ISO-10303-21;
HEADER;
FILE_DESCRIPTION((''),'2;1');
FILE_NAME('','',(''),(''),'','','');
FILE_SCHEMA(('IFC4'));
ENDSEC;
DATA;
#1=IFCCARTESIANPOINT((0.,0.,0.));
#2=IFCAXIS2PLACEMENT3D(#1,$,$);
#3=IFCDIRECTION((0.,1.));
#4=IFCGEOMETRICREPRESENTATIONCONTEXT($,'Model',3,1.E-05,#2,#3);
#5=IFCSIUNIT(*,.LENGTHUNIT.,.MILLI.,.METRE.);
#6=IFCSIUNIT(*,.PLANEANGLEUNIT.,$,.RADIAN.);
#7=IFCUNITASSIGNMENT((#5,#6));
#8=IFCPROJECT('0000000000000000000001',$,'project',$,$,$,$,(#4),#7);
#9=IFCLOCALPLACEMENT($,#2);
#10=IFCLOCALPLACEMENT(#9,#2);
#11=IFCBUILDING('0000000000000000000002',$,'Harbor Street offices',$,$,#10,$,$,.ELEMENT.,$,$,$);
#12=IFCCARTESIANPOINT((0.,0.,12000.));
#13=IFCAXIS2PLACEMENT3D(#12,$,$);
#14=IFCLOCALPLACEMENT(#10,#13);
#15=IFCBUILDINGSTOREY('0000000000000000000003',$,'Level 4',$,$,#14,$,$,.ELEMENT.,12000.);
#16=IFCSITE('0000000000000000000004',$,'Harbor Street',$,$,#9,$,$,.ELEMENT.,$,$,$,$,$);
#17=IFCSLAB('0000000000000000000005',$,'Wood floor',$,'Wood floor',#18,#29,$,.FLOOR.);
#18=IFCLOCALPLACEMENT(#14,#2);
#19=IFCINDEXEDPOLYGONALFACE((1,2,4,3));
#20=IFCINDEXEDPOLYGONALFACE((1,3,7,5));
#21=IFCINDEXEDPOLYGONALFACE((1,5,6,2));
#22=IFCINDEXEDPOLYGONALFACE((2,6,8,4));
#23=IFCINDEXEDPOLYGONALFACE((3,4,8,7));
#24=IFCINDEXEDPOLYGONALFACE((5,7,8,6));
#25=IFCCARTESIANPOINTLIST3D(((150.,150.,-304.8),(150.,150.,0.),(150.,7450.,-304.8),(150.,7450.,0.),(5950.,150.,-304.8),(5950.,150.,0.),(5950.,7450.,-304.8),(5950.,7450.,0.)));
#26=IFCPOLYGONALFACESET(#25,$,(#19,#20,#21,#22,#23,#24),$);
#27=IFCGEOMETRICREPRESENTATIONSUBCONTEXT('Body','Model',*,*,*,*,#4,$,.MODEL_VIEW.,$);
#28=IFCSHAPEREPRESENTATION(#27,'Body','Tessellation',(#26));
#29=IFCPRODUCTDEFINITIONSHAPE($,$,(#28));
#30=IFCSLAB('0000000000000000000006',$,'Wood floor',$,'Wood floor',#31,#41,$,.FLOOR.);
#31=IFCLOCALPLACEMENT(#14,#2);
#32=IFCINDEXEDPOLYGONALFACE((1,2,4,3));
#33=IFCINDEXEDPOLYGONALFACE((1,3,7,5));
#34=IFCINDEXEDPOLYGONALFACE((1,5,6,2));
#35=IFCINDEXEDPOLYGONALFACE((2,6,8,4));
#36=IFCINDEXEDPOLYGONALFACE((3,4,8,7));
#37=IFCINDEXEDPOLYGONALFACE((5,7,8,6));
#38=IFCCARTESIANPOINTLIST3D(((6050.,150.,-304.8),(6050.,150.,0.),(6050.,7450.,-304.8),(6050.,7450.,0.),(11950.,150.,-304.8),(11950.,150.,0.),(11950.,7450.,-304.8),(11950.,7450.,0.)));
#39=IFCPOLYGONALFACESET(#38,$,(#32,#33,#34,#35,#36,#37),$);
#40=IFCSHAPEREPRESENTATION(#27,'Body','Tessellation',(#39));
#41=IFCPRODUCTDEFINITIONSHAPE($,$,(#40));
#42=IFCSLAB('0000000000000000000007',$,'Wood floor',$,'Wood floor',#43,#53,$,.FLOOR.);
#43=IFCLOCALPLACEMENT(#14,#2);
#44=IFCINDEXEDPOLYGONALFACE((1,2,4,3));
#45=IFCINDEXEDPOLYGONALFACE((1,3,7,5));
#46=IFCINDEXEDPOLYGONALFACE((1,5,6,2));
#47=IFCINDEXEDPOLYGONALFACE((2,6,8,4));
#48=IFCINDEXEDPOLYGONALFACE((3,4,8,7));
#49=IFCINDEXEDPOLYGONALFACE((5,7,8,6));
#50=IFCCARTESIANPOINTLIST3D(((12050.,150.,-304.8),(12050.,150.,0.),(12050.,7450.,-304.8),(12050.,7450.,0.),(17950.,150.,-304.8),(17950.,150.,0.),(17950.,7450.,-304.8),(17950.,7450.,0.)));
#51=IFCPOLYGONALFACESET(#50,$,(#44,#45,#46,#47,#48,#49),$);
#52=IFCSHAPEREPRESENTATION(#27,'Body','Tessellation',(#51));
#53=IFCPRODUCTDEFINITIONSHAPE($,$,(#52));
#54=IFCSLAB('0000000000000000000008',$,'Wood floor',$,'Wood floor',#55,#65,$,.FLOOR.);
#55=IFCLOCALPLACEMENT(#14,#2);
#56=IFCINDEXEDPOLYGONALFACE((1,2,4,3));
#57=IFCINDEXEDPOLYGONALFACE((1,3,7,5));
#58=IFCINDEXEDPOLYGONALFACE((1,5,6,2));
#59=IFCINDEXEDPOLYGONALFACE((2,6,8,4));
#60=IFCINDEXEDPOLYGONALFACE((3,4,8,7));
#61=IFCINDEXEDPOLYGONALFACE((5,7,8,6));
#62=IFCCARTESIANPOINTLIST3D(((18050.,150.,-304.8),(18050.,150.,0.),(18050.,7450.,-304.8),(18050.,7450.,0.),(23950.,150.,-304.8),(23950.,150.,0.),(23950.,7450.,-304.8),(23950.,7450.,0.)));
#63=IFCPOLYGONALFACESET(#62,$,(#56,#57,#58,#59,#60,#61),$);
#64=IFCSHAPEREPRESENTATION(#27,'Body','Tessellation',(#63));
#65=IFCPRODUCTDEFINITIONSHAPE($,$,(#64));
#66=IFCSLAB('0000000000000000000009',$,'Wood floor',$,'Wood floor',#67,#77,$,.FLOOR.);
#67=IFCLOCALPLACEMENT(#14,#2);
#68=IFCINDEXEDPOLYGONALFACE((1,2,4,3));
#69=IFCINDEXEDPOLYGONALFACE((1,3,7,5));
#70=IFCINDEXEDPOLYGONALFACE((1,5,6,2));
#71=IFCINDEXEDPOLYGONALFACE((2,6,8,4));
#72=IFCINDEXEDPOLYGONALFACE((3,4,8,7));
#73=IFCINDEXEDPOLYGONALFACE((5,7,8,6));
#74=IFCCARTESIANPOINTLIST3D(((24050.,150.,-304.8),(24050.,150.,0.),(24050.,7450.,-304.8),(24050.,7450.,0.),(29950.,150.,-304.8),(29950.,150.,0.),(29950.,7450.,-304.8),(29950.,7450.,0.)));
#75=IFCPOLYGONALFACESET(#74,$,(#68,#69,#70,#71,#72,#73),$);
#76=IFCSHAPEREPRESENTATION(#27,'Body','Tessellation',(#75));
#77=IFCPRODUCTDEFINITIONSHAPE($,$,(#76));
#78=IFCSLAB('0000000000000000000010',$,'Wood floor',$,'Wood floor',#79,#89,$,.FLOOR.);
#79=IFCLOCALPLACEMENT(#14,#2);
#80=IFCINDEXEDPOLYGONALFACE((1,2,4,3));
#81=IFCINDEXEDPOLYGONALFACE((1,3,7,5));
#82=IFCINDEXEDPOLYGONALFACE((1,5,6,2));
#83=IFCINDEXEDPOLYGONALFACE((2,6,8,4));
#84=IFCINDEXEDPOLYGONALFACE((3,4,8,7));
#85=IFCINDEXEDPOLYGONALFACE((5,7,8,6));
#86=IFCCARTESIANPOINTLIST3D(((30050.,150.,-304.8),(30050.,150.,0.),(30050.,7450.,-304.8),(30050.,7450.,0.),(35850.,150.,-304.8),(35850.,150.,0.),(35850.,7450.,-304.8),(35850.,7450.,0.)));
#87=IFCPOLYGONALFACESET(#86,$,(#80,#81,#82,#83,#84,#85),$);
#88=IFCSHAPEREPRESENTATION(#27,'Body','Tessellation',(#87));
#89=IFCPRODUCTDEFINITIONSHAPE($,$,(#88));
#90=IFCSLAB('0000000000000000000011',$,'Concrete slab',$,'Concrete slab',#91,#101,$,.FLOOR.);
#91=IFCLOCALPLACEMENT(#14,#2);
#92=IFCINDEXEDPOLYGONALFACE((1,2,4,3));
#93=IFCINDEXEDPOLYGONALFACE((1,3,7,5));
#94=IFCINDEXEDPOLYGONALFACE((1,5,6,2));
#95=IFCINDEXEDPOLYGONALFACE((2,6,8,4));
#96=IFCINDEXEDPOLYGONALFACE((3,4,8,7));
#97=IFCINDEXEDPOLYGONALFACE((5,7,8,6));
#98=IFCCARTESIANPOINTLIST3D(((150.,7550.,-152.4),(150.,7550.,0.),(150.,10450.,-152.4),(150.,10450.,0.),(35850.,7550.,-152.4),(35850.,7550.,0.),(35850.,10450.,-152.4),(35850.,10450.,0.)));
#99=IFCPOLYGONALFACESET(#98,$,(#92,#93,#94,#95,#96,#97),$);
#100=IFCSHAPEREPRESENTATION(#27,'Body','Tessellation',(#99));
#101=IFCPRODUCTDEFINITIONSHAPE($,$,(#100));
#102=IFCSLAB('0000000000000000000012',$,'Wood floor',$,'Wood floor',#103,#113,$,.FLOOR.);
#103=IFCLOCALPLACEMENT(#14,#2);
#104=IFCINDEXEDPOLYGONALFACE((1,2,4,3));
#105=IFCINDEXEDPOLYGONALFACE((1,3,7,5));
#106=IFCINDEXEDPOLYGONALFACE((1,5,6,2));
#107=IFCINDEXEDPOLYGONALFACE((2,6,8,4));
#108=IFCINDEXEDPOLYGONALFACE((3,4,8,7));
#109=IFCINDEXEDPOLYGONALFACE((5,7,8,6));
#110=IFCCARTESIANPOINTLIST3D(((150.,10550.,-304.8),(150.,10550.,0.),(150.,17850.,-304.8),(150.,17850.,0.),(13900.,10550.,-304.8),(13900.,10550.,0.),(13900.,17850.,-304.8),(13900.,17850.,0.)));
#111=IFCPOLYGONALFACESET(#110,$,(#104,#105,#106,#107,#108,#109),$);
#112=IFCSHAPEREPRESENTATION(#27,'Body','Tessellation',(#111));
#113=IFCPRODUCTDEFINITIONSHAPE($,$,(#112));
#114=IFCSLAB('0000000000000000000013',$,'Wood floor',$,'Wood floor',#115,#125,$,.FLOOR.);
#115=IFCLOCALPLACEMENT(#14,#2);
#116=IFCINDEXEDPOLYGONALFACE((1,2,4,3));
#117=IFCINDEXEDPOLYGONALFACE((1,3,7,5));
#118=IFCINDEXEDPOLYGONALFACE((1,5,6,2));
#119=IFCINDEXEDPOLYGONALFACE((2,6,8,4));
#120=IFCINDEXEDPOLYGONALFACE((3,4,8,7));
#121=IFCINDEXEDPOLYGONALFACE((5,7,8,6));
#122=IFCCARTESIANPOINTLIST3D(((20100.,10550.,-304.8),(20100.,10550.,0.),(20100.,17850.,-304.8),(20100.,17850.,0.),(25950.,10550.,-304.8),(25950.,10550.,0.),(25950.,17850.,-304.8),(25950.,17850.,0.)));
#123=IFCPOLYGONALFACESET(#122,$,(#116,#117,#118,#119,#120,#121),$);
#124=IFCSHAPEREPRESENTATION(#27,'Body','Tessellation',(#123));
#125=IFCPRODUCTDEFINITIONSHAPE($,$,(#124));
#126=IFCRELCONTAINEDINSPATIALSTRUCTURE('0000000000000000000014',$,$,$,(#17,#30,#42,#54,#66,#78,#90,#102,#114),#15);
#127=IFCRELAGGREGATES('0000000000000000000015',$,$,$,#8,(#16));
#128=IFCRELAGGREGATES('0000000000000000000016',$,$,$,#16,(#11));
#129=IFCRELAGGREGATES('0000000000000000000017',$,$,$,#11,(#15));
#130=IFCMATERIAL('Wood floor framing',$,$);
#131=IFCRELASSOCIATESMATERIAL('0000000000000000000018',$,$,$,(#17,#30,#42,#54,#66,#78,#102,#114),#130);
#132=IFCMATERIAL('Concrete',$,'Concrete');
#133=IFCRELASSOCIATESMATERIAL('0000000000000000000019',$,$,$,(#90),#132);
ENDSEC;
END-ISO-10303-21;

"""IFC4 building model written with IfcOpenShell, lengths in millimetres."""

from ifc_helpers import new_model, si_unit, direction, frame, origin, origin_with_axes, place, context, subcontext, project, spatial, polyline, outline, extrude, material, element, save


model = new_model("IFC4")

# Units and contexts
model_context = context("Model", 3, precision=1e-05, world=origin(), true_north=direction((0.0, 1.0)))
body_context = subcontext(model_context, "Body", "Model", "MODEL_VIEW")
ifc_project = project(units=[si_unit("LENGTHUNIT", "METRE", prefix="MILLI"), si_unit("PLANEANGLEUNIT", "RADIAN")], contexts=[model_context])

# Site, building, storey
site_placement = place(None, origin())
site = spatial("IfcSite", under=ifc_project, at=site_placement, Name="Harbor Street", CompositionType="ELEMENT")
building_placement = place(site_placement, origin())
building = spatial("IfcBuilding", under=site, at=building_placement, Name="Harbor Street offices", CompositionType="ELEMENT")
storey_placement = place(building_placement, frame((0.0, 0.0, 12000.0)))
storey = spatial("IfcBuildingStorey", under=building, at=storey_placement, Name="Level 4", CompositionType="ELEMENT", Elevation=12000.0)

# Slabs
ifc_material_1 = material(Name="Wood floor framing")
slab_1_placement = place(storey_placement, origin_with_axes())
element("IfcSlab", 1, at=slab_1_placement, inside=storey, material=ifc_material_1, Name="Wood floor", ObjectType="Wood floor", PredefinedType="FLOOR", context=body_context, shape_type="SweptSolid", body=[
    extrude(outline(polyline([(150.0, 150.0), (5950.0, 150.0), (5950.0, 7450.0), (150.0, 7450.0), (150.0, 150.0)])), frame((0.0, 0.0, -304.8)), (0.0, 0.0, 1.0), 304.8),
])
slab_2_placement = place(storey_placement, origin_with_axes())
element("IfcSlab", 2, at=slab_2_placement, inside=storey, material=ifc_material_1, Name="Wood floor", ObjectType="Wood floor", PredefinedType="FLOOR", context=body_context, shape_type="SweptSolid", body=[
    extrude(outline(polyline([(6050.0, 150.0), (11950.0, 150.0), (11950.0, 7450.0), (6050.0, 7450.0), (6050.0, 150.0)])), frame((0.0, 0.0, -304.8)), (0.0, 0.0, 1.0), 304.8),
])
slab_3_placement = place(storey_placement, origin_with_axes())
element("IfcSlab", 3, at=slab_3_placement, inside=storey, material=ifc_material_1, Name="Wood floor", ObjectType="Wood floor", PredefinedType="FLOOR", context=body_context, shape_type="SweptSolid", body=[
    extrude(outline(polyline([(12050.0, 150.0), (17950.0, 150.0), (17950.0, 7450.0), (12050.0, 7450.0), (12050.0, 150.0)])), frame((0.0, 0.0, -304.8)), (0.0, 0.0, 1.0), 304.8),
])
slab_4_placement = place(storey_placement, origin_with_axes())
element("IfcSlab", 4, at=slab_4_placement, inside=storey, material=ifc_material_1, Name="Wood floor", ObjectType="Wood floor", PredefinedType="FLOOR", context=body_context, shape_type="SweptSolid", body=[
    extrude(outline(polyline([(18050.0, 150.0), (23950.0, 150.0), (23950.0, 7450.0), (18050.0, 7450.0), (18050.0, 150.0)])), frame((0.0, 0.0, -304.8)), (0.0, 0.0, 1.0), 304.8),
])
slab_5_placement = place(storey_placement, origin_with_axes())
element("IfcSlab", 5, at=slab_5_placement, inside=storey, material=ifc_material_1, Name="Wood floor", ObjectType="Wood floor", PredefinedType="FLOOR", context=body_context, shape_type="SweptSolid", body=[
    extrude(outline(polyline([(24050.0, 150.0), (29950.0, 150.0), (29950.0, 7450.0), (24050.0, 7450.0), (24050.0, 150.0)])), frame((0.0, 0.0, -304.8)), (0.0, 0.0, 1.0), 304.8),
])
slab_6_placement = place(storey_placement, origin_with_axes())
element("IfcSlab", 6, at=slab_6_placement, inside=storey, material=ifc_material_1, Name="Wood floor", ObjectType="Wood floor", PredefinedType="FLOOR", context=body_context, shape_type="SweptSolid", body=[
    extrude(outline(polyline([(30050.0, 150.0), (35850.0, 150.0), (35850.0, 7450.0), (30050.0, 7450.0), (30050.0, 150.0)])), frame((0.0, 0.0, -304.8)), (0.0, 0.0, 1.0), 304.8),
])
ifc_material_2 = material(Name="Concrete", Category="Concrete")
slab_7_placement = place(storey_placement, origin_with_axes())
element("IfcSlab", 7, at=slab_7_placement, inside=storey, material=ifc_material_2, Name="Concrete slab", ObjectType="Concrete slab", PredefinedType="FLOOR", context=body_context, shape_type="SweptSolid", body=[
    extrude(outline(polyline([(35850.0, 7550.0), (35850.0, 10450.0), (150.0, 10450.0), (150.0, 7550.0), (35850.0, 7550.0)])), frame((0.0, 0.0, -152.4)), (0.0, 0.0, 1.0), 152.4),
])
slab_8_placement = place(storey_placement, origin_with_axes())
element("IfcSlab", 8, at=slab_8_placement, inside=storey, material=ifc_material_1, Name="Wood floor", ObjectType="Wood floor", PredefinedType="FLOOR", context=body_context, shape_type="SweptSolid", body=[
    extrude(outline(polyline([(13900.0, 17850.0), (150.0, 17850.0), (150.0, 10550.0), (13900.0, 10550.0), (13900.0, 17850.0)])), frame((0.0, 0.0, -304.8)), (0.0, 0.0, 1.0), 304.8),
])
slab_9_placement = place(storey_placement, origin_with_axes())
element("IfcSlab", 9, at=slab_9_placement, inside=storey, material=ifc_material_1, Name="Wood floor", ObjectType="Wood floor", PredefinedType="FLOOR", context=body_context, shape_type="SweptSolid", body=[
    extrude(outline(polyline([(25950.0, 17850.0), (20100.0, 17850.0), (20100.0, 10550.0), (25950.0, 10550.0), (25950.0, 17850.0)])), frame((0.0, 0.0, -304.8)), (0.0, 0.0, 1.0), 304.8),
])

save(model, "model.ifc")
